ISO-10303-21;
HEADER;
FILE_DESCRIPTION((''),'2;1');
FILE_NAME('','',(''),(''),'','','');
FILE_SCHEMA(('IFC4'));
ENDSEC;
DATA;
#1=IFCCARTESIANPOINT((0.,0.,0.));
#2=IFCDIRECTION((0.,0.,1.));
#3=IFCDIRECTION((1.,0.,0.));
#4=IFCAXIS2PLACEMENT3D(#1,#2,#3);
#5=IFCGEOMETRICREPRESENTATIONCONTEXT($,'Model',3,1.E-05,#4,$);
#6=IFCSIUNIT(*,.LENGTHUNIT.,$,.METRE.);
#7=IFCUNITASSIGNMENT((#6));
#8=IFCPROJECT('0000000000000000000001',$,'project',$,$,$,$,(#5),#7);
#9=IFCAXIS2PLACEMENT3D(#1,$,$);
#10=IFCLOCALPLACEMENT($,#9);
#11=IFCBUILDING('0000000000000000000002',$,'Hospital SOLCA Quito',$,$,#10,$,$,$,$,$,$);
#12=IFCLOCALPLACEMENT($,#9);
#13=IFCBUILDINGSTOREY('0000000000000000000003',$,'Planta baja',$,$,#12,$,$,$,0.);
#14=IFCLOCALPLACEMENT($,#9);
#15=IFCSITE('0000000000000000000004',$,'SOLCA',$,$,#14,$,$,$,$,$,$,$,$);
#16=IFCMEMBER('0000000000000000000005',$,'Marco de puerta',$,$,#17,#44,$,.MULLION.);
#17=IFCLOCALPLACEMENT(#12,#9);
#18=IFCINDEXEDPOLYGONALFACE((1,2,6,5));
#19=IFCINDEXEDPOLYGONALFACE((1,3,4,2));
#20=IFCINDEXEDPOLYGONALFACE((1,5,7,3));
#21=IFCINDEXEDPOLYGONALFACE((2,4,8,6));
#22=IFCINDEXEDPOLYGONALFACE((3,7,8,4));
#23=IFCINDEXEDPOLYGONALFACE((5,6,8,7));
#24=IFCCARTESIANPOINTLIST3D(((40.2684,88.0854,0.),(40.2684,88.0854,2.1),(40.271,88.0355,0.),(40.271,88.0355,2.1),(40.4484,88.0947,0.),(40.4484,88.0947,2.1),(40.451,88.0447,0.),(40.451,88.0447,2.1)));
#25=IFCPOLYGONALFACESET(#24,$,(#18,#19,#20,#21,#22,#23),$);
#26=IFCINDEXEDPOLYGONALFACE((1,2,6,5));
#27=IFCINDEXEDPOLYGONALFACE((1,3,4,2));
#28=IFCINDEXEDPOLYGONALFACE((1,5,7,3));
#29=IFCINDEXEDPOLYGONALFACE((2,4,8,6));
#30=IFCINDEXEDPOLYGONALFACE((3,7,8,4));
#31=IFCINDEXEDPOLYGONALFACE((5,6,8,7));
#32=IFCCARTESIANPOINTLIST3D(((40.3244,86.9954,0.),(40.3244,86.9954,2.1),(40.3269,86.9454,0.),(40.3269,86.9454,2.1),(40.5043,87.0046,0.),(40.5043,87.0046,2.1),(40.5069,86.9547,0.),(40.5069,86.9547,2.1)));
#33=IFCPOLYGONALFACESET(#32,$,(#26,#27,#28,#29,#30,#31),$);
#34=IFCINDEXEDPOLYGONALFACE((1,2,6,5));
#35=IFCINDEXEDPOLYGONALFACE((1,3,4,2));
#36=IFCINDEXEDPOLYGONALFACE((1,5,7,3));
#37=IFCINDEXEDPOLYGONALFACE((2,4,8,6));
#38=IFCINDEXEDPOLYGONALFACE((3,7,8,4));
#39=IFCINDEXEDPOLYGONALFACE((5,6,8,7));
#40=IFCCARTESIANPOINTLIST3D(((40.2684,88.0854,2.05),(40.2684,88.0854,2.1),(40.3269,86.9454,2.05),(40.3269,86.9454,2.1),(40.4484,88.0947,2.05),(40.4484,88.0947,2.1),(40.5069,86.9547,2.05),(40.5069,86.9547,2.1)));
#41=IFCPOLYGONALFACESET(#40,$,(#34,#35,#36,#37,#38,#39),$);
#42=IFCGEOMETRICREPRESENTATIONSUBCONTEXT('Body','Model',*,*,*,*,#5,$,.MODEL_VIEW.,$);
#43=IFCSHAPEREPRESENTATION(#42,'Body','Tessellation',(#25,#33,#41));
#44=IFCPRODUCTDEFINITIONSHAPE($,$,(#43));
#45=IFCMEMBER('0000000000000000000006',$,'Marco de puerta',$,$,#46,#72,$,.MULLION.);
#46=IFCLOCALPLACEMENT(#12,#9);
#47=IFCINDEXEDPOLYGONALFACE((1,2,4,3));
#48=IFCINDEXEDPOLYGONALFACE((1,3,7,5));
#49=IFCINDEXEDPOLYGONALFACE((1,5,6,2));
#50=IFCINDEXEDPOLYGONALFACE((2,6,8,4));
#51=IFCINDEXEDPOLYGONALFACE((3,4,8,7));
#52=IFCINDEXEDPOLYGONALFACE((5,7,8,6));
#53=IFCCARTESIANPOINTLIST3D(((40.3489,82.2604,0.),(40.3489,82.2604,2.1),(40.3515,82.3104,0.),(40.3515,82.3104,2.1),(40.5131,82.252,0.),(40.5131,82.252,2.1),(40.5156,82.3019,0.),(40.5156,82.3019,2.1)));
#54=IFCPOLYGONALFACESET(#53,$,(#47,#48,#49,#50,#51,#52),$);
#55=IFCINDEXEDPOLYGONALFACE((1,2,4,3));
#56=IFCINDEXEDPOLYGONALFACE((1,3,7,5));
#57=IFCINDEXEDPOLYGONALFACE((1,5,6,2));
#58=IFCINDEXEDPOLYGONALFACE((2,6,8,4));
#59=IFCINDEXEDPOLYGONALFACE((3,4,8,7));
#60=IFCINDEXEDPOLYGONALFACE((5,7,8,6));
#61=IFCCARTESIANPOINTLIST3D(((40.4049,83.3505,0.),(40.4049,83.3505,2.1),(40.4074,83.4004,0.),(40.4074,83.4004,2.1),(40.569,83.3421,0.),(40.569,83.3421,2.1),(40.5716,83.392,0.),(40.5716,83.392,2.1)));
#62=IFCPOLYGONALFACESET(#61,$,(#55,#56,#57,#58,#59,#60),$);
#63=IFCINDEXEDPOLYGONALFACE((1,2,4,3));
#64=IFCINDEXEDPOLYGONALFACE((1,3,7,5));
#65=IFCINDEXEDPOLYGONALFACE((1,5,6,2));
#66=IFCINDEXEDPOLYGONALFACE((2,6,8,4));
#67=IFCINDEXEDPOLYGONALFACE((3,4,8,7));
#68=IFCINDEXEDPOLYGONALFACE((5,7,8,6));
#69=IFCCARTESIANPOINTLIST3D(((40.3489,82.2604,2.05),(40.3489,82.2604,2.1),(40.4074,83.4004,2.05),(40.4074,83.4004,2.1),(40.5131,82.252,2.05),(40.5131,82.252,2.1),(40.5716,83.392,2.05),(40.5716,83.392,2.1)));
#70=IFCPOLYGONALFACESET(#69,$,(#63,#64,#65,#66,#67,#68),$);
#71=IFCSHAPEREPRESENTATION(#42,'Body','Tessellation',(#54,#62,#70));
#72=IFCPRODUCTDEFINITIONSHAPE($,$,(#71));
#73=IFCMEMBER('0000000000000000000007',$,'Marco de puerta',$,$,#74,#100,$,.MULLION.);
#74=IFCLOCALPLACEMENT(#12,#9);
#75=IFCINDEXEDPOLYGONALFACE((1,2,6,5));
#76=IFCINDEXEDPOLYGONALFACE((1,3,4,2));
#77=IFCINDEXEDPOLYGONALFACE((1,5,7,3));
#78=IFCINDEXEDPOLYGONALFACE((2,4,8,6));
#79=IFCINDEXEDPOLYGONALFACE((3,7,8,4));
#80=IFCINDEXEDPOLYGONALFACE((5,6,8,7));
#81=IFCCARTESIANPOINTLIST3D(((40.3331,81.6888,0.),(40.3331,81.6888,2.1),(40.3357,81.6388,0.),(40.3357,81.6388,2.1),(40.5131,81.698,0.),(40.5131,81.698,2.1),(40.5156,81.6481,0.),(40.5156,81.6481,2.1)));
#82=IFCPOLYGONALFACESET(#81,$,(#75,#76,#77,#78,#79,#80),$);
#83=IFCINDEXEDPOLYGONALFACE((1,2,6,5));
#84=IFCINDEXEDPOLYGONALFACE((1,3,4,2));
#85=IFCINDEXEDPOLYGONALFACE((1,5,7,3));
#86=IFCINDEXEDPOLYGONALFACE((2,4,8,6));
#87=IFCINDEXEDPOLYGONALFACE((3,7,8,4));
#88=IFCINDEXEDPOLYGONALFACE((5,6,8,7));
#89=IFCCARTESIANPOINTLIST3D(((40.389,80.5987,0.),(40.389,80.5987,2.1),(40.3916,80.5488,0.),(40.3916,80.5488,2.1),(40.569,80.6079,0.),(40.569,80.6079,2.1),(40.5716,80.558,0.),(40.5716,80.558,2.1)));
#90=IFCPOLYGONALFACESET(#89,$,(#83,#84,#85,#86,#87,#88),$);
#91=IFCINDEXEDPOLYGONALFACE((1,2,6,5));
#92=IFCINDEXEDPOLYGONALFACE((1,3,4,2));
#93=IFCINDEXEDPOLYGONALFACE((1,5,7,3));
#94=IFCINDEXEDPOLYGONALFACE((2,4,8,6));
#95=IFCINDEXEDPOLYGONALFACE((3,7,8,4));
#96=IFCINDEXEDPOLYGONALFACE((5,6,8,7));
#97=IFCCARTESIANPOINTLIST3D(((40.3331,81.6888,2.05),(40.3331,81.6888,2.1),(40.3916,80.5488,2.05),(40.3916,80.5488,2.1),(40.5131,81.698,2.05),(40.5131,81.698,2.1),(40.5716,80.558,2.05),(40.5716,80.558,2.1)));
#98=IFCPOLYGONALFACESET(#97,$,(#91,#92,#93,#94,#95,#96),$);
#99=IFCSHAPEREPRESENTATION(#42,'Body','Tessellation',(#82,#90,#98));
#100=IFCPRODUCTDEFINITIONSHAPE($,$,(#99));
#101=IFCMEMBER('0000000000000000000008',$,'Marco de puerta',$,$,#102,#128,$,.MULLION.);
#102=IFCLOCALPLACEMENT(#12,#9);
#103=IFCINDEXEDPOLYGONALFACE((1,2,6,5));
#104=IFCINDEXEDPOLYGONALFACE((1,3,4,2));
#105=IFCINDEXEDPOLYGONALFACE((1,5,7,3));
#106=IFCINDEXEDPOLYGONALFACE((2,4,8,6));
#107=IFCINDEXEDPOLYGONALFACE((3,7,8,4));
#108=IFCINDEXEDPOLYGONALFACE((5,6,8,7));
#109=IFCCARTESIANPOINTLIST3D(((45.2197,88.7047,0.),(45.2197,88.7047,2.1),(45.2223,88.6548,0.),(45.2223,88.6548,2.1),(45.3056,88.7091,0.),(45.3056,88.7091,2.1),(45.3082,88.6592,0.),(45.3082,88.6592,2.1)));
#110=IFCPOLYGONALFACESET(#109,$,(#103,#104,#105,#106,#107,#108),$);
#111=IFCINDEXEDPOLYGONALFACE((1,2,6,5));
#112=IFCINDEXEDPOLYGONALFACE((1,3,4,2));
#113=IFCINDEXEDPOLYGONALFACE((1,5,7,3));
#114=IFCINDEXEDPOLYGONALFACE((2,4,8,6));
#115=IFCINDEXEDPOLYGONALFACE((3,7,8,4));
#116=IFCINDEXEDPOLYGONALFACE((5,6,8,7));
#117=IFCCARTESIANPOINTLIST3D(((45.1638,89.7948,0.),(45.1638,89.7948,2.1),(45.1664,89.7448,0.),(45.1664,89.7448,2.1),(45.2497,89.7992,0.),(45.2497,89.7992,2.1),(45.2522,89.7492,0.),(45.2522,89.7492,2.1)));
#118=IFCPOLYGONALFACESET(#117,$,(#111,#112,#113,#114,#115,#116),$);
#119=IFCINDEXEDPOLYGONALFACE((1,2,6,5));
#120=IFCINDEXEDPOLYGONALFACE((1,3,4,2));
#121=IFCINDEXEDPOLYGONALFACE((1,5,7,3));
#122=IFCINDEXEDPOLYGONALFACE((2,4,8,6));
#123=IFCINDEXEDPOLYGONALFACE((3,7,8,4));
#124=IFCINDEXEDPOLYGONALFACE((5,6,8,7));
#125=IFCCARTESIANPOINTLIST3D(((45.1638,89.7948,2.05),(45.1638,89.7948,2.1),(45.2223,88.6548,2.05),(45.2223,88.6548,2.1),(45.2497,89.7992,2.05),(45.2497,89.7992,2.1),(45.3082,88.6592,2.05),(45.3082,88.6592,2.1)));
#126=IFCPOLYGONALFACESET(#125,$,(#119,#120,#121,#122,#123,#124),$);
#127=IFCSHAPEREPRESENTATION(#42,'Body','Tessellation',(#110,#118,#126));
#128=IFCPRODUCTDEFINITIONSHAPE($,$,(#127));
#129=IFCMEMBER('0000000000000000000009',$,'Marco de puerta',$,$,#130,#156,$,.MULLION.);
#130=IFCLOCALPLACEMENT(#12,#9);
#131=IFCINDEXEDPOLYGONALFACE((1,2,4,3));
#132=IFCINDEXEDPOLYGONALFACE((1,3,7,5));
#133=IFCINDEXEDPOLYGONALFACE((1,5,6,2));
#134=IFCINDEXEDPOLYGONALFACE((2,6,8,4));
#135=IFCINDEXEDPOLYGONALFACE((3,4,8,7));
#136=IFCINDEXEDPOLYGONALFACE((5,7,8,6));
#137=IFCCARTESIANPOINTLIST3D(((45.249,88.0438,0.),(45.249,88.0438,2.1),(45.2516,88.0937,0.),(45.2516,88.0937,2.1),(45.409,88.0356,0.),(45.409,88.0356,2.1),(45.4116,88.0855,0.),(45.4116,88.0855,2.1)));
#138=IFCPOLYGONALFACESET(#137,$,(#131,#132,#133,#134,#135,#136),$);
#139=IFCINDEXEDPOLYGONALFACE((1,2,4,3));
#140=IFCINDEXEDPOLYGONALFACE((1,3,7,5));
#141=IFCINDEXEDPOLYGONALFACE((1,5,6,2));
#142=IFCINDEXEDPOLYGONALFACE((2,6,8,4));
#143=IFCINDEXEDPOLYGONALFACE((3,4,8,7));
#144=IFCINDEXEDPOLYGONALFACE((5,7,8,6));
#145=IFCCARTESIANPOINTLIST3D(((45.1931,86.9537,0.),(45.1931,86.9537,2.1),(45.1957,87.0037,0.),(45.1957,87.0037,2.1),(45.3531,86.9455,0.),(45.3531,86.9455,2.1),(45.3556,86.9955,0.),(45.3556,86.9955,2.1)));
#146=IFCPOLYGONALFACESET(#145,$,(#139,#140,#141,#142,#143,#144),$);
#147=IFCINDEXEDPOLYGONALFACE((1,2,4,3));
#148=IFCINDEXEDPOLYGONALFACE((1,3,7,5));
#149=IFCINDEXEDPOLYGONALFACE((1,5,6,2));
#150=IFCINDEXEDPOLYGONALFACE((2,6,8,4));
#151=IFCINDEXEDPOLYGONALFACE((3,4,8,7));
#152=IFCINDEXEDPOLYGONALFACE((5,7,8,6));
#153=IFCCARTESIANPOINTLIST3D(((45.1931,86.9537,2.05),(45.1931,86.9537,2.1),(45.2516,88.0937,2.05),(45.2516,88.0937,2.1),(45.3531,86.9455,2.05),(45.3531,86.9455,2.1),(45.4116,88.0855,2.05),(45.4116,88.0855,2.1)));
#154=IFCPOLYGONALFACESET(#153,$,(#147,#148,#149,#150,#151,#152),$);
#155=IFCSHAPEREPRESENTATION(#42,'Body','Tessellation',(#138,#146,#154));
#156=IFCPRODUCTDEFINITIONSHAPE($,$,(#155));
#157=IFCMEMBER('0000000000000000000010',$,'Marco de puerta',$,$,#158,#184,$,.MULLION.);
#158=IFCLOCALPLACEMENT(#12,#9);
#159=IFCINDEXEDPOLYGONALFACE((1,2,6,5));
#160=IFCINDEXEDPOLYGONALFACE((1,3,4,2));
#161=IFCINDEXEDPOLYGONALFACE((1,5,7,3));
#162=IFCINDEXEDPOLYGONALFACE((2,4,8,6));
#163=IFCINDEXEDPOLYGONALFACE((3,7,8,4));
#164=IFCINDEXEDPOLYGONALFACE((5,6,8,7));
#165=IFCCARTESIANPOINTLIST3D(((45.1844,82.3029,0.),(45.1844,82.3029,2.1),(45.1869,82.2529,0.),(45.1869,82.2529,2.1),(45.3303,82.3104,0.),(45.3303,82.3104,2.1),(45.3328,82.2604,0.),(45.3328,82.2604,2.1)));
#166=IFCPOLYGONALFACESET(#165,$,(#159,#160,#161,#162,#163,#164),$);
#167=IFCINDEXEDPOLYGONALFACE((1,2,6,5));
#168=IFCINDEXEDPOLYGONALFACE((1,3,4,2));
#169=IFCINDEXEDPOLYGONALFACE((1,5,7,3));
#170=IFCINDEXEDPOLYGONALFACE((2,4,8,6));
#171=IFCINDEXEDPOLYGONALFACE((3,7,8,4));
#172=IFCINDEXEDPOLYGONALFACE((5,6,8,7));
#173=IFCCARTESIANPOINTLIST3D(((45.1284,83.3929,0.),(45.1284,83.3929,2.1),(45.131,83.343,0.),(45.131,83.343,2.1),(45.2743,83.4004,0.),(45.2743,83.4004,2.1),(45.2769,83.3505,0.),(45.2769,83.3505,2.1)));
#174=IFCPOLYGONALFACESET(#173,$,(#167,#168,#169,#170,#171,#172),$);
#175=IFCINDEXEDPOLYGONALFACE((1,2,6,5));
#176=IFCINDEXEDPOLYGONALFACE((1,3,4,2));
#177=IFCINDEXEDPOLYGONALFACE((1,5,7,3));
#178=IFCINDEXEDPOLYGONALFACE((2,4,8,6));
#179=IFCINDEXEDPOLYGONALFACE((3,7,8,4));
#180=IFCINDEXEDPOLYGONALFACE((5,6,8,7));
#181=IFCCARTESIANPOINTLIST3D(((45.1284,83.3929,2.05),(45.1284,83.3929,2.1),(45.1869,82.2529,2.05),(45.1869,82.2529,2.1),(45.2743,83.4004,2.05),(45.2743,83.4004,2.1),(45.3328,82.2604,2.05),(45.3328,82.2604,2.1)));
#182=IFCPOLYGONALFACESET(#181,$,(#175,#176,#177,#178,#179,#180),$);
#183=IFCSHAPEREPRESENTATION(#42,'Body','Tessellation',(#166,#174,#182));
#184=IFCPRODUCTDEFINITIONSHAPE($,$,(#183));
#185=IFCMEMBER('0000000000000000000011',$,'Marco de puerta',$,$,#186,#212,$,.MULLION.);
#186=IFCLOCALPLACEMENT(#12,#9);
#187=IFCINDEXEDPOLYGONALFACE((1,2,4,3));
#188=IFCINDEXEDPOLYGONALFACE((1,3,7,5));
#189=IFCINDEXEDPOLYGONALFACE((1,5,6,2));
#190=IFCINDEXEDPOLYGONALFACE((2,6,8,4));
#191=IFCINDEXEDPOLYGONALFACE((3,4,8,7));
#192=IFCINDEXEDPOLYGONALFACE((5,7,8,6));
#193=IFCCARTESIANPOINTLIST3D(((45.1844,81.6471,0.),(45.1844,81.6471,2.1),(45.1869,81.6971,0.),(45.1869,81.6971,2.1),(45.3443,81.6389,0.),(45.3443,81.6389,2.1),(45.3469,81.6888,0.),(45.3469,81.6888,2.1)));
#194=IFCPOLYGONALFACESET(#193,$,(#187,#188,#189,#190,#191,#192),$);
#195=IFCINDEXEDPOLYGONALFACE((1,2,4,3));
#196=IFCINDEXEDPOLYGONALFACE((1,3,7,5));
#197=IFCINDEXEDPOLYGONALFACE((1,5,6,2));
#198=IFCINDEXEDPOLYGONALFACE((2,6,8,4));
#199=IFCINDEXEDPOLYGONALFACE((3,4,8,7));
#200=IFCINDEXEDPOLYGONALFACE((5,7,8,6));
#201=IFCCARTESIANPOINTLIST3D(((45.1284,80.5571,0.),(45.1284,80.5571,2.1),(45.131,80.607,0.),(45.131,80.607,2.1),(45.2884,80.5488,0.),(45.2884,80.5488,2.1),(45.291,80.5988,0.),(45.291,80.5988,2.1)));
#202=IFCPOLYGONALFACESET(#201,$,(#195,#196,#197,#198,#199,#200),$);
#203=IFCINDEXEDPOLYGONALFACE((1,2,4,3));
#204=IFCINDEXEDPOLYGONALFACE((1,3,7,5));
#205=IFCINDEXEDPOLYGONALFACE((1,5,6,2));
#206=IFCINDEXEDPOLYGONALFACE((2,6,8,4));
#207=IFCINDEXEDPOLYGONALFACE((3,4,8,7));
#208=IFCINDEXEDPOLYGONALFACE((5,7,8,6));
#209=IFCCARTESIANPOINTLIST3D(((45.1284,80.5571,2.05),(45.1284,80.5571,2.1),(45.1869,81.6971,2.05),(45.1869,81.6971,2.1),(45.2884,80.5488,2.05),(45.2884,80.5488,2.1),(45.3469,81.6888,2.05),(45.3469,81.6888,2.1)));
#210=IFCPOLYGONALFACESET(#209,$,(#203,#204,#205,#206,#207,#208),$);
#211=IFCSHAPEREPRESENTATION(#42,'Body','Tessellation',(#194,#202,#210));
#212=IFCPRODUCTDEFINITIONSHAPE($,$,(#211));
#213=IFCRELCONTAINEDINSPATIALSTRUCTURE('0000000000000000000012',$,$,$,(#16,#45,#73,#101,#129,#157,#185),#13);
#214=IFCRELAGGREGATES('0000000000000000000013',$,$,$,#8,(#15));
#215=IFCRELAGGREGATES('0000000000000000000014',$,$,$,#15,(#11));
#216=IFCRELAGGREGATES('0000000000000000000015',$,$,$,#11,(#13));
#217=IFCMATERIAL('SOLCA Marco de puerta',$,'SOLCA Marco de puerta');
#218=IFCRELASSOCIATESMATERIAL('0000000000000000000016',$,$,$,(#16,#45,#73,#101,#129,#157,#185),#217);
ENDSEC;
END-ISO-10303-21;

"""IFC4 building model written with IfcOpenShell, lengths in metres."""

from ifc_helpers import new_model, si_unit, frame, origin, origin_with_axes, place, context, subcontext, project, spatial, polyline, outline, extrude, material, element, save


model = new_model("IFC4")

# Units and contexts
model_context = context("Model", 3, precision=1e-05, world=origin_with_axes())
body_context = subcontext(model_context, "Body", "Model", "MODEL_VIEW")
ifc_project = project(units=[si_unit("LENGTHUNIT", "METRE")], contexts=[model_context])

# Site, building, storey
site_placement = place(None, origin())
site = spatial("IfcSite", under=ifc_project, at=site_placement, Name="SOLCA")
building_placement = place(None, origin())
building = spatial("IfcBuilding", under=site, at=building_placement, Name="Hospital SOLCA Quito")
storey_placement = place(None, origin())
storey = spatial("IfcBuildingStorey", under=building, at=storey_placement, Name="Planta baja", Elevation=0.0)

# Members
ifc_material_1 = material(Name="SOLCA Marco de puerta", Category="SOLCA Marco de puerta")
member_1_placement = place(storey_placement, origin_with_axes())
element("IfcMember", 1, at=member_1_placement, inside=storey, material=ifc_material_1, Name="Marco de puerta", PredefinedType="MULLION", context=body_context, shape_type="SweptSolid", body=[
    extrude(outline(polyline([(40.2684, 88.0854), (40.271, 88.0355), (40.451, 88.0447), (40.4484, 88.0947), (40.2684, 88.0854)])), origin_with_axes(), (0.0, 0.0, 1.0), 2.1),
    extrude(outline(polyline([(40.3244, 86.9954), (40.3269, 86.9454), (40.5069, 86.9547), (40.5043, 87.0046), (40.3244, 86.9954)])), origin_with_axes(), (0.0, 0.0, 1.0), 2.1),
    extrude(outline(polyline([(40.2684, 88.0854), (40.3269, 86.9454), (40.5069, 86.9547), (40.4484, 88.0947), (40.2684, 88.0854)])), frame((0.0, 0.0, 2.05), z_axis=(0.0, 0.0, 1.0), x_axis=(1.0, 0.0, 0.0)), (0.0, 0.0, 1.0), 0.05),
])
member_2_placement = place(storey_placement, origin_with_axes())
element("IfcMember", 2, at=member_2_placement, inside=storey, material=ifc_material_1, Name="Marco de puerta", PredefinedType="MULLION", context=body_context, shape_type="SweptSolid", body=[
    extrude(outline(polyline([(40.5131, 82.252), (40.5156, 82.3019), (40.3515, 82.3104), (40.3489, 82.2604), (40.5131, 82.252)])), origin_with_axes(), (0.0, 0.0, 1.0), 2.1),
    extrude(outline(polyline([(40.569, 83.3421), (40.5716, 83.392), (40.4074, 83.4004), (40.4049, 83.3505), (40.569, 83.3421)])), origin_with_axes(), (0.0, 0.0, 1.0), 2.1),
    extrude(outline(polyline([(40.5131, 82.252), (40.5716, 83.392), (40.4074, 83.4004), (40.3489, 82.2604), (40.5131, 82.252)])), frame((0.0, 0.0, 2.05), z_axis=(0.0, 0.0, 1.0), x_axis=(1.0, 0.0, 0.0)), (0.0, 0.0, 1.0), 0.05),
])
member_3_placement = place(storey_placement, origin_with_axes())
element("IfcMember", 3, at=member_3_placement, inside=storey, material=ifc_material_1, Name="Marco de puerta", PredefinedType="MULLION", context=body_context, shape_type="SweptSolid", body=[
    extrude(outline(polyline([(40.3331, 81.6888), (40.3357, 81.6388), (40.5156, 81.6481), (40.5131, 81.698), (40.3331, 81.6888)])), origin_with_axes(), (0.0, 0.0, 1.0), 2.1),
    extrude(outline(polyline([(40.389, 80.5987), (40.3916, 80.5488), (40.5716, 80.558), (40.569, 80.6079), (40.389, 80.5987)])), origin_with_axes(), (0.0, 0.0, 1.0), 2.1),
    extrude(outline(polyline([(40.3331, 81.6888), (40.3916, 80.5488), (40.5716, 80.558), (40.5131, 81.698), (40.3331, 81.6888)])), frame((0.0, 0.0, 2.05), z_axis=(0.0, 0.0, 1.0), x_axis=(1.0, 0.0, 0.0)), (0.0, 0.0, 1.0), 0.05),
])
member_4_placement = place(storey_placement, origin_with_axes())
element("IfcMember", 4, at=member_4_placement, inside=storey, material=ifc_material_1, Name="Marco de puerta", PredefinedType="MULLION", context=body_context, shape_type="SweptSolid", body=[
    extrude(outline(polyline([(45.3082, 88.6592), (45.3056, 88.7091), (45.2197, 88.7047), (45.2223, 88.6548), (45.3082, 88.6592)])), origin_with_axes(), (0.0, 0.0, 1.0), 2.1),
    extrude(outline(polyline([(45.2522, 89.7492), (45.2497, 89.7992), (45.1638, 89.7948), (45.1664, 89.7448), (45.2522, 89.7492)])), origin_with_axes(), (0.0, 0.0, 1.0), 2.1),
    extrude(outline(polyline([(45.3082, 88.6592), (45.2497, 89.7992), (45.1638, 89.7948), (45.2223, 88.6548), (45.3082, 88.6592)])), frame((0.0, 0.0, 2.05), z_axis=(0.0, 0.0, 1.0), x_axis=(1.0, 0.0, 0.0)), (0.0, 0.0, 1.0), 0.05),
])
member_5_placement = place(storey_placement, origin_with_axes())
element("IfcMember", 5, at=member_5_placement, inside=storey, material=ifc_material_1, Name="Marco de puerta", PredefinedType="MULLION", context=body_context, shape_type="SweptSolid", body=[
    extrude(outline(polyline([(45.2516, 88.0937), (45.249, 88.0438), (45.409, 88.0356), (45.4116, 88.0855), (45.2516, 88.0937)])), origin_with_axes(), (0.0, 0.0, 1.0), 2.1),
    extrude(outline(polyline([(45.1957, 87.0037), (45.1931, 86.9537), (45.3531, 86.9455), (45.3556, 86.9955), (45.1957, 87.0037)])), origin_with_axes(), (0.0, 0.0, 1.0), 2.1),
    extrude(outline(polyline([(45.2516, 88.0937), (45.1931, 86.9537), (45.3531, 86.9455), (45.4116, 88.0855), (45.2516, 88.0937)])), frame((0.0, 0.0, 2.05), z_axis=(0.0, 0.0, 1.0), x_axis=(1.0, 0.0, 0.0)), (0.0, 0.0, 1.0), 0.05),
])
member_6_placement = place(storey_placement, origin_with_axes())
element("IfcMember", 6, at=member_6_placement, inside=storey, material=ifc_material_1, Name="Marco de puerta", PredefinedType="MULLION", context=body_context, shape_type="SweptSolid", body=[
    extrude(outline(polyline([(45.3328, 82.2604), (45.3303, 82.3104), (45.1844, 82.3029), (45.1869, 82.2529), (45.3328, 82.2604)])), origin_with_axes(), (0.0, 0.0, 1.0), 2.1),
    extrude(outline(polyline([(45.2769, 83.3505), (45.2743, 83.4004), (45.1284, 83.3929), (45.131, 83.343), (45.2769, 83.3505)])), origin_with_axes(), (0.0, 0.0, 1.0), 2.1),
    extrude(outline(polyline([(45.3328, 82.2604), (45.2743, 83.4004), (45.1284, 83.3929), (45.1869, 82.2529), (45.3328, 82.2604)])), frame((0.0, 0.0, 2.05), z_axis=(0.0, 0.0, 1.0), x_axis=(1.0, 0.0, 0.0)), (0.0, 0.0, 1.0), 0.05),
])
member_7_placement = place(storey_placement, origin_with_axes())
element("IfcMember", 7, at=member_7_placement, inside=storey, material=ifc_material_1, Name="Marco de puerta", PredefinedType="MULLION", context=body_context, shape_type="SweptSolid", body=[
    extrude(outline(polyline([(45.1869, 81.6971), (45.1844, 81.6471), (45.3443, 81.6389), (45.3469, 81.6888), (45.1869, 81.6971)])), origin_with_axes(), (0.0, 0.0, 1.0), 2.1),
    extrude(outline(polyline([(45.131, 80.607), (45.1284, 80.5571), (45.2884, 80.5488), (45.291, 80.5988), (45.131, 80.607)])), origin_with_axes(), (0.0, 0.0, 1.0), 2.1),
    extrude(outline(polyline([(45.1869, 81.6971), (45.1284, 80.5571), (45.2884, 80.5488), (45.3469, 81.6888), (45.1869, 81.6971)])), frame((0.0, 0.0, 2.05), z_axis=(0.0, 0.0, 1.0), x_axis=(1.0, 0.0, 0.0)), (0.0, 0.0, 1.0), 0.05),
])

save(model, "model.ifc")
